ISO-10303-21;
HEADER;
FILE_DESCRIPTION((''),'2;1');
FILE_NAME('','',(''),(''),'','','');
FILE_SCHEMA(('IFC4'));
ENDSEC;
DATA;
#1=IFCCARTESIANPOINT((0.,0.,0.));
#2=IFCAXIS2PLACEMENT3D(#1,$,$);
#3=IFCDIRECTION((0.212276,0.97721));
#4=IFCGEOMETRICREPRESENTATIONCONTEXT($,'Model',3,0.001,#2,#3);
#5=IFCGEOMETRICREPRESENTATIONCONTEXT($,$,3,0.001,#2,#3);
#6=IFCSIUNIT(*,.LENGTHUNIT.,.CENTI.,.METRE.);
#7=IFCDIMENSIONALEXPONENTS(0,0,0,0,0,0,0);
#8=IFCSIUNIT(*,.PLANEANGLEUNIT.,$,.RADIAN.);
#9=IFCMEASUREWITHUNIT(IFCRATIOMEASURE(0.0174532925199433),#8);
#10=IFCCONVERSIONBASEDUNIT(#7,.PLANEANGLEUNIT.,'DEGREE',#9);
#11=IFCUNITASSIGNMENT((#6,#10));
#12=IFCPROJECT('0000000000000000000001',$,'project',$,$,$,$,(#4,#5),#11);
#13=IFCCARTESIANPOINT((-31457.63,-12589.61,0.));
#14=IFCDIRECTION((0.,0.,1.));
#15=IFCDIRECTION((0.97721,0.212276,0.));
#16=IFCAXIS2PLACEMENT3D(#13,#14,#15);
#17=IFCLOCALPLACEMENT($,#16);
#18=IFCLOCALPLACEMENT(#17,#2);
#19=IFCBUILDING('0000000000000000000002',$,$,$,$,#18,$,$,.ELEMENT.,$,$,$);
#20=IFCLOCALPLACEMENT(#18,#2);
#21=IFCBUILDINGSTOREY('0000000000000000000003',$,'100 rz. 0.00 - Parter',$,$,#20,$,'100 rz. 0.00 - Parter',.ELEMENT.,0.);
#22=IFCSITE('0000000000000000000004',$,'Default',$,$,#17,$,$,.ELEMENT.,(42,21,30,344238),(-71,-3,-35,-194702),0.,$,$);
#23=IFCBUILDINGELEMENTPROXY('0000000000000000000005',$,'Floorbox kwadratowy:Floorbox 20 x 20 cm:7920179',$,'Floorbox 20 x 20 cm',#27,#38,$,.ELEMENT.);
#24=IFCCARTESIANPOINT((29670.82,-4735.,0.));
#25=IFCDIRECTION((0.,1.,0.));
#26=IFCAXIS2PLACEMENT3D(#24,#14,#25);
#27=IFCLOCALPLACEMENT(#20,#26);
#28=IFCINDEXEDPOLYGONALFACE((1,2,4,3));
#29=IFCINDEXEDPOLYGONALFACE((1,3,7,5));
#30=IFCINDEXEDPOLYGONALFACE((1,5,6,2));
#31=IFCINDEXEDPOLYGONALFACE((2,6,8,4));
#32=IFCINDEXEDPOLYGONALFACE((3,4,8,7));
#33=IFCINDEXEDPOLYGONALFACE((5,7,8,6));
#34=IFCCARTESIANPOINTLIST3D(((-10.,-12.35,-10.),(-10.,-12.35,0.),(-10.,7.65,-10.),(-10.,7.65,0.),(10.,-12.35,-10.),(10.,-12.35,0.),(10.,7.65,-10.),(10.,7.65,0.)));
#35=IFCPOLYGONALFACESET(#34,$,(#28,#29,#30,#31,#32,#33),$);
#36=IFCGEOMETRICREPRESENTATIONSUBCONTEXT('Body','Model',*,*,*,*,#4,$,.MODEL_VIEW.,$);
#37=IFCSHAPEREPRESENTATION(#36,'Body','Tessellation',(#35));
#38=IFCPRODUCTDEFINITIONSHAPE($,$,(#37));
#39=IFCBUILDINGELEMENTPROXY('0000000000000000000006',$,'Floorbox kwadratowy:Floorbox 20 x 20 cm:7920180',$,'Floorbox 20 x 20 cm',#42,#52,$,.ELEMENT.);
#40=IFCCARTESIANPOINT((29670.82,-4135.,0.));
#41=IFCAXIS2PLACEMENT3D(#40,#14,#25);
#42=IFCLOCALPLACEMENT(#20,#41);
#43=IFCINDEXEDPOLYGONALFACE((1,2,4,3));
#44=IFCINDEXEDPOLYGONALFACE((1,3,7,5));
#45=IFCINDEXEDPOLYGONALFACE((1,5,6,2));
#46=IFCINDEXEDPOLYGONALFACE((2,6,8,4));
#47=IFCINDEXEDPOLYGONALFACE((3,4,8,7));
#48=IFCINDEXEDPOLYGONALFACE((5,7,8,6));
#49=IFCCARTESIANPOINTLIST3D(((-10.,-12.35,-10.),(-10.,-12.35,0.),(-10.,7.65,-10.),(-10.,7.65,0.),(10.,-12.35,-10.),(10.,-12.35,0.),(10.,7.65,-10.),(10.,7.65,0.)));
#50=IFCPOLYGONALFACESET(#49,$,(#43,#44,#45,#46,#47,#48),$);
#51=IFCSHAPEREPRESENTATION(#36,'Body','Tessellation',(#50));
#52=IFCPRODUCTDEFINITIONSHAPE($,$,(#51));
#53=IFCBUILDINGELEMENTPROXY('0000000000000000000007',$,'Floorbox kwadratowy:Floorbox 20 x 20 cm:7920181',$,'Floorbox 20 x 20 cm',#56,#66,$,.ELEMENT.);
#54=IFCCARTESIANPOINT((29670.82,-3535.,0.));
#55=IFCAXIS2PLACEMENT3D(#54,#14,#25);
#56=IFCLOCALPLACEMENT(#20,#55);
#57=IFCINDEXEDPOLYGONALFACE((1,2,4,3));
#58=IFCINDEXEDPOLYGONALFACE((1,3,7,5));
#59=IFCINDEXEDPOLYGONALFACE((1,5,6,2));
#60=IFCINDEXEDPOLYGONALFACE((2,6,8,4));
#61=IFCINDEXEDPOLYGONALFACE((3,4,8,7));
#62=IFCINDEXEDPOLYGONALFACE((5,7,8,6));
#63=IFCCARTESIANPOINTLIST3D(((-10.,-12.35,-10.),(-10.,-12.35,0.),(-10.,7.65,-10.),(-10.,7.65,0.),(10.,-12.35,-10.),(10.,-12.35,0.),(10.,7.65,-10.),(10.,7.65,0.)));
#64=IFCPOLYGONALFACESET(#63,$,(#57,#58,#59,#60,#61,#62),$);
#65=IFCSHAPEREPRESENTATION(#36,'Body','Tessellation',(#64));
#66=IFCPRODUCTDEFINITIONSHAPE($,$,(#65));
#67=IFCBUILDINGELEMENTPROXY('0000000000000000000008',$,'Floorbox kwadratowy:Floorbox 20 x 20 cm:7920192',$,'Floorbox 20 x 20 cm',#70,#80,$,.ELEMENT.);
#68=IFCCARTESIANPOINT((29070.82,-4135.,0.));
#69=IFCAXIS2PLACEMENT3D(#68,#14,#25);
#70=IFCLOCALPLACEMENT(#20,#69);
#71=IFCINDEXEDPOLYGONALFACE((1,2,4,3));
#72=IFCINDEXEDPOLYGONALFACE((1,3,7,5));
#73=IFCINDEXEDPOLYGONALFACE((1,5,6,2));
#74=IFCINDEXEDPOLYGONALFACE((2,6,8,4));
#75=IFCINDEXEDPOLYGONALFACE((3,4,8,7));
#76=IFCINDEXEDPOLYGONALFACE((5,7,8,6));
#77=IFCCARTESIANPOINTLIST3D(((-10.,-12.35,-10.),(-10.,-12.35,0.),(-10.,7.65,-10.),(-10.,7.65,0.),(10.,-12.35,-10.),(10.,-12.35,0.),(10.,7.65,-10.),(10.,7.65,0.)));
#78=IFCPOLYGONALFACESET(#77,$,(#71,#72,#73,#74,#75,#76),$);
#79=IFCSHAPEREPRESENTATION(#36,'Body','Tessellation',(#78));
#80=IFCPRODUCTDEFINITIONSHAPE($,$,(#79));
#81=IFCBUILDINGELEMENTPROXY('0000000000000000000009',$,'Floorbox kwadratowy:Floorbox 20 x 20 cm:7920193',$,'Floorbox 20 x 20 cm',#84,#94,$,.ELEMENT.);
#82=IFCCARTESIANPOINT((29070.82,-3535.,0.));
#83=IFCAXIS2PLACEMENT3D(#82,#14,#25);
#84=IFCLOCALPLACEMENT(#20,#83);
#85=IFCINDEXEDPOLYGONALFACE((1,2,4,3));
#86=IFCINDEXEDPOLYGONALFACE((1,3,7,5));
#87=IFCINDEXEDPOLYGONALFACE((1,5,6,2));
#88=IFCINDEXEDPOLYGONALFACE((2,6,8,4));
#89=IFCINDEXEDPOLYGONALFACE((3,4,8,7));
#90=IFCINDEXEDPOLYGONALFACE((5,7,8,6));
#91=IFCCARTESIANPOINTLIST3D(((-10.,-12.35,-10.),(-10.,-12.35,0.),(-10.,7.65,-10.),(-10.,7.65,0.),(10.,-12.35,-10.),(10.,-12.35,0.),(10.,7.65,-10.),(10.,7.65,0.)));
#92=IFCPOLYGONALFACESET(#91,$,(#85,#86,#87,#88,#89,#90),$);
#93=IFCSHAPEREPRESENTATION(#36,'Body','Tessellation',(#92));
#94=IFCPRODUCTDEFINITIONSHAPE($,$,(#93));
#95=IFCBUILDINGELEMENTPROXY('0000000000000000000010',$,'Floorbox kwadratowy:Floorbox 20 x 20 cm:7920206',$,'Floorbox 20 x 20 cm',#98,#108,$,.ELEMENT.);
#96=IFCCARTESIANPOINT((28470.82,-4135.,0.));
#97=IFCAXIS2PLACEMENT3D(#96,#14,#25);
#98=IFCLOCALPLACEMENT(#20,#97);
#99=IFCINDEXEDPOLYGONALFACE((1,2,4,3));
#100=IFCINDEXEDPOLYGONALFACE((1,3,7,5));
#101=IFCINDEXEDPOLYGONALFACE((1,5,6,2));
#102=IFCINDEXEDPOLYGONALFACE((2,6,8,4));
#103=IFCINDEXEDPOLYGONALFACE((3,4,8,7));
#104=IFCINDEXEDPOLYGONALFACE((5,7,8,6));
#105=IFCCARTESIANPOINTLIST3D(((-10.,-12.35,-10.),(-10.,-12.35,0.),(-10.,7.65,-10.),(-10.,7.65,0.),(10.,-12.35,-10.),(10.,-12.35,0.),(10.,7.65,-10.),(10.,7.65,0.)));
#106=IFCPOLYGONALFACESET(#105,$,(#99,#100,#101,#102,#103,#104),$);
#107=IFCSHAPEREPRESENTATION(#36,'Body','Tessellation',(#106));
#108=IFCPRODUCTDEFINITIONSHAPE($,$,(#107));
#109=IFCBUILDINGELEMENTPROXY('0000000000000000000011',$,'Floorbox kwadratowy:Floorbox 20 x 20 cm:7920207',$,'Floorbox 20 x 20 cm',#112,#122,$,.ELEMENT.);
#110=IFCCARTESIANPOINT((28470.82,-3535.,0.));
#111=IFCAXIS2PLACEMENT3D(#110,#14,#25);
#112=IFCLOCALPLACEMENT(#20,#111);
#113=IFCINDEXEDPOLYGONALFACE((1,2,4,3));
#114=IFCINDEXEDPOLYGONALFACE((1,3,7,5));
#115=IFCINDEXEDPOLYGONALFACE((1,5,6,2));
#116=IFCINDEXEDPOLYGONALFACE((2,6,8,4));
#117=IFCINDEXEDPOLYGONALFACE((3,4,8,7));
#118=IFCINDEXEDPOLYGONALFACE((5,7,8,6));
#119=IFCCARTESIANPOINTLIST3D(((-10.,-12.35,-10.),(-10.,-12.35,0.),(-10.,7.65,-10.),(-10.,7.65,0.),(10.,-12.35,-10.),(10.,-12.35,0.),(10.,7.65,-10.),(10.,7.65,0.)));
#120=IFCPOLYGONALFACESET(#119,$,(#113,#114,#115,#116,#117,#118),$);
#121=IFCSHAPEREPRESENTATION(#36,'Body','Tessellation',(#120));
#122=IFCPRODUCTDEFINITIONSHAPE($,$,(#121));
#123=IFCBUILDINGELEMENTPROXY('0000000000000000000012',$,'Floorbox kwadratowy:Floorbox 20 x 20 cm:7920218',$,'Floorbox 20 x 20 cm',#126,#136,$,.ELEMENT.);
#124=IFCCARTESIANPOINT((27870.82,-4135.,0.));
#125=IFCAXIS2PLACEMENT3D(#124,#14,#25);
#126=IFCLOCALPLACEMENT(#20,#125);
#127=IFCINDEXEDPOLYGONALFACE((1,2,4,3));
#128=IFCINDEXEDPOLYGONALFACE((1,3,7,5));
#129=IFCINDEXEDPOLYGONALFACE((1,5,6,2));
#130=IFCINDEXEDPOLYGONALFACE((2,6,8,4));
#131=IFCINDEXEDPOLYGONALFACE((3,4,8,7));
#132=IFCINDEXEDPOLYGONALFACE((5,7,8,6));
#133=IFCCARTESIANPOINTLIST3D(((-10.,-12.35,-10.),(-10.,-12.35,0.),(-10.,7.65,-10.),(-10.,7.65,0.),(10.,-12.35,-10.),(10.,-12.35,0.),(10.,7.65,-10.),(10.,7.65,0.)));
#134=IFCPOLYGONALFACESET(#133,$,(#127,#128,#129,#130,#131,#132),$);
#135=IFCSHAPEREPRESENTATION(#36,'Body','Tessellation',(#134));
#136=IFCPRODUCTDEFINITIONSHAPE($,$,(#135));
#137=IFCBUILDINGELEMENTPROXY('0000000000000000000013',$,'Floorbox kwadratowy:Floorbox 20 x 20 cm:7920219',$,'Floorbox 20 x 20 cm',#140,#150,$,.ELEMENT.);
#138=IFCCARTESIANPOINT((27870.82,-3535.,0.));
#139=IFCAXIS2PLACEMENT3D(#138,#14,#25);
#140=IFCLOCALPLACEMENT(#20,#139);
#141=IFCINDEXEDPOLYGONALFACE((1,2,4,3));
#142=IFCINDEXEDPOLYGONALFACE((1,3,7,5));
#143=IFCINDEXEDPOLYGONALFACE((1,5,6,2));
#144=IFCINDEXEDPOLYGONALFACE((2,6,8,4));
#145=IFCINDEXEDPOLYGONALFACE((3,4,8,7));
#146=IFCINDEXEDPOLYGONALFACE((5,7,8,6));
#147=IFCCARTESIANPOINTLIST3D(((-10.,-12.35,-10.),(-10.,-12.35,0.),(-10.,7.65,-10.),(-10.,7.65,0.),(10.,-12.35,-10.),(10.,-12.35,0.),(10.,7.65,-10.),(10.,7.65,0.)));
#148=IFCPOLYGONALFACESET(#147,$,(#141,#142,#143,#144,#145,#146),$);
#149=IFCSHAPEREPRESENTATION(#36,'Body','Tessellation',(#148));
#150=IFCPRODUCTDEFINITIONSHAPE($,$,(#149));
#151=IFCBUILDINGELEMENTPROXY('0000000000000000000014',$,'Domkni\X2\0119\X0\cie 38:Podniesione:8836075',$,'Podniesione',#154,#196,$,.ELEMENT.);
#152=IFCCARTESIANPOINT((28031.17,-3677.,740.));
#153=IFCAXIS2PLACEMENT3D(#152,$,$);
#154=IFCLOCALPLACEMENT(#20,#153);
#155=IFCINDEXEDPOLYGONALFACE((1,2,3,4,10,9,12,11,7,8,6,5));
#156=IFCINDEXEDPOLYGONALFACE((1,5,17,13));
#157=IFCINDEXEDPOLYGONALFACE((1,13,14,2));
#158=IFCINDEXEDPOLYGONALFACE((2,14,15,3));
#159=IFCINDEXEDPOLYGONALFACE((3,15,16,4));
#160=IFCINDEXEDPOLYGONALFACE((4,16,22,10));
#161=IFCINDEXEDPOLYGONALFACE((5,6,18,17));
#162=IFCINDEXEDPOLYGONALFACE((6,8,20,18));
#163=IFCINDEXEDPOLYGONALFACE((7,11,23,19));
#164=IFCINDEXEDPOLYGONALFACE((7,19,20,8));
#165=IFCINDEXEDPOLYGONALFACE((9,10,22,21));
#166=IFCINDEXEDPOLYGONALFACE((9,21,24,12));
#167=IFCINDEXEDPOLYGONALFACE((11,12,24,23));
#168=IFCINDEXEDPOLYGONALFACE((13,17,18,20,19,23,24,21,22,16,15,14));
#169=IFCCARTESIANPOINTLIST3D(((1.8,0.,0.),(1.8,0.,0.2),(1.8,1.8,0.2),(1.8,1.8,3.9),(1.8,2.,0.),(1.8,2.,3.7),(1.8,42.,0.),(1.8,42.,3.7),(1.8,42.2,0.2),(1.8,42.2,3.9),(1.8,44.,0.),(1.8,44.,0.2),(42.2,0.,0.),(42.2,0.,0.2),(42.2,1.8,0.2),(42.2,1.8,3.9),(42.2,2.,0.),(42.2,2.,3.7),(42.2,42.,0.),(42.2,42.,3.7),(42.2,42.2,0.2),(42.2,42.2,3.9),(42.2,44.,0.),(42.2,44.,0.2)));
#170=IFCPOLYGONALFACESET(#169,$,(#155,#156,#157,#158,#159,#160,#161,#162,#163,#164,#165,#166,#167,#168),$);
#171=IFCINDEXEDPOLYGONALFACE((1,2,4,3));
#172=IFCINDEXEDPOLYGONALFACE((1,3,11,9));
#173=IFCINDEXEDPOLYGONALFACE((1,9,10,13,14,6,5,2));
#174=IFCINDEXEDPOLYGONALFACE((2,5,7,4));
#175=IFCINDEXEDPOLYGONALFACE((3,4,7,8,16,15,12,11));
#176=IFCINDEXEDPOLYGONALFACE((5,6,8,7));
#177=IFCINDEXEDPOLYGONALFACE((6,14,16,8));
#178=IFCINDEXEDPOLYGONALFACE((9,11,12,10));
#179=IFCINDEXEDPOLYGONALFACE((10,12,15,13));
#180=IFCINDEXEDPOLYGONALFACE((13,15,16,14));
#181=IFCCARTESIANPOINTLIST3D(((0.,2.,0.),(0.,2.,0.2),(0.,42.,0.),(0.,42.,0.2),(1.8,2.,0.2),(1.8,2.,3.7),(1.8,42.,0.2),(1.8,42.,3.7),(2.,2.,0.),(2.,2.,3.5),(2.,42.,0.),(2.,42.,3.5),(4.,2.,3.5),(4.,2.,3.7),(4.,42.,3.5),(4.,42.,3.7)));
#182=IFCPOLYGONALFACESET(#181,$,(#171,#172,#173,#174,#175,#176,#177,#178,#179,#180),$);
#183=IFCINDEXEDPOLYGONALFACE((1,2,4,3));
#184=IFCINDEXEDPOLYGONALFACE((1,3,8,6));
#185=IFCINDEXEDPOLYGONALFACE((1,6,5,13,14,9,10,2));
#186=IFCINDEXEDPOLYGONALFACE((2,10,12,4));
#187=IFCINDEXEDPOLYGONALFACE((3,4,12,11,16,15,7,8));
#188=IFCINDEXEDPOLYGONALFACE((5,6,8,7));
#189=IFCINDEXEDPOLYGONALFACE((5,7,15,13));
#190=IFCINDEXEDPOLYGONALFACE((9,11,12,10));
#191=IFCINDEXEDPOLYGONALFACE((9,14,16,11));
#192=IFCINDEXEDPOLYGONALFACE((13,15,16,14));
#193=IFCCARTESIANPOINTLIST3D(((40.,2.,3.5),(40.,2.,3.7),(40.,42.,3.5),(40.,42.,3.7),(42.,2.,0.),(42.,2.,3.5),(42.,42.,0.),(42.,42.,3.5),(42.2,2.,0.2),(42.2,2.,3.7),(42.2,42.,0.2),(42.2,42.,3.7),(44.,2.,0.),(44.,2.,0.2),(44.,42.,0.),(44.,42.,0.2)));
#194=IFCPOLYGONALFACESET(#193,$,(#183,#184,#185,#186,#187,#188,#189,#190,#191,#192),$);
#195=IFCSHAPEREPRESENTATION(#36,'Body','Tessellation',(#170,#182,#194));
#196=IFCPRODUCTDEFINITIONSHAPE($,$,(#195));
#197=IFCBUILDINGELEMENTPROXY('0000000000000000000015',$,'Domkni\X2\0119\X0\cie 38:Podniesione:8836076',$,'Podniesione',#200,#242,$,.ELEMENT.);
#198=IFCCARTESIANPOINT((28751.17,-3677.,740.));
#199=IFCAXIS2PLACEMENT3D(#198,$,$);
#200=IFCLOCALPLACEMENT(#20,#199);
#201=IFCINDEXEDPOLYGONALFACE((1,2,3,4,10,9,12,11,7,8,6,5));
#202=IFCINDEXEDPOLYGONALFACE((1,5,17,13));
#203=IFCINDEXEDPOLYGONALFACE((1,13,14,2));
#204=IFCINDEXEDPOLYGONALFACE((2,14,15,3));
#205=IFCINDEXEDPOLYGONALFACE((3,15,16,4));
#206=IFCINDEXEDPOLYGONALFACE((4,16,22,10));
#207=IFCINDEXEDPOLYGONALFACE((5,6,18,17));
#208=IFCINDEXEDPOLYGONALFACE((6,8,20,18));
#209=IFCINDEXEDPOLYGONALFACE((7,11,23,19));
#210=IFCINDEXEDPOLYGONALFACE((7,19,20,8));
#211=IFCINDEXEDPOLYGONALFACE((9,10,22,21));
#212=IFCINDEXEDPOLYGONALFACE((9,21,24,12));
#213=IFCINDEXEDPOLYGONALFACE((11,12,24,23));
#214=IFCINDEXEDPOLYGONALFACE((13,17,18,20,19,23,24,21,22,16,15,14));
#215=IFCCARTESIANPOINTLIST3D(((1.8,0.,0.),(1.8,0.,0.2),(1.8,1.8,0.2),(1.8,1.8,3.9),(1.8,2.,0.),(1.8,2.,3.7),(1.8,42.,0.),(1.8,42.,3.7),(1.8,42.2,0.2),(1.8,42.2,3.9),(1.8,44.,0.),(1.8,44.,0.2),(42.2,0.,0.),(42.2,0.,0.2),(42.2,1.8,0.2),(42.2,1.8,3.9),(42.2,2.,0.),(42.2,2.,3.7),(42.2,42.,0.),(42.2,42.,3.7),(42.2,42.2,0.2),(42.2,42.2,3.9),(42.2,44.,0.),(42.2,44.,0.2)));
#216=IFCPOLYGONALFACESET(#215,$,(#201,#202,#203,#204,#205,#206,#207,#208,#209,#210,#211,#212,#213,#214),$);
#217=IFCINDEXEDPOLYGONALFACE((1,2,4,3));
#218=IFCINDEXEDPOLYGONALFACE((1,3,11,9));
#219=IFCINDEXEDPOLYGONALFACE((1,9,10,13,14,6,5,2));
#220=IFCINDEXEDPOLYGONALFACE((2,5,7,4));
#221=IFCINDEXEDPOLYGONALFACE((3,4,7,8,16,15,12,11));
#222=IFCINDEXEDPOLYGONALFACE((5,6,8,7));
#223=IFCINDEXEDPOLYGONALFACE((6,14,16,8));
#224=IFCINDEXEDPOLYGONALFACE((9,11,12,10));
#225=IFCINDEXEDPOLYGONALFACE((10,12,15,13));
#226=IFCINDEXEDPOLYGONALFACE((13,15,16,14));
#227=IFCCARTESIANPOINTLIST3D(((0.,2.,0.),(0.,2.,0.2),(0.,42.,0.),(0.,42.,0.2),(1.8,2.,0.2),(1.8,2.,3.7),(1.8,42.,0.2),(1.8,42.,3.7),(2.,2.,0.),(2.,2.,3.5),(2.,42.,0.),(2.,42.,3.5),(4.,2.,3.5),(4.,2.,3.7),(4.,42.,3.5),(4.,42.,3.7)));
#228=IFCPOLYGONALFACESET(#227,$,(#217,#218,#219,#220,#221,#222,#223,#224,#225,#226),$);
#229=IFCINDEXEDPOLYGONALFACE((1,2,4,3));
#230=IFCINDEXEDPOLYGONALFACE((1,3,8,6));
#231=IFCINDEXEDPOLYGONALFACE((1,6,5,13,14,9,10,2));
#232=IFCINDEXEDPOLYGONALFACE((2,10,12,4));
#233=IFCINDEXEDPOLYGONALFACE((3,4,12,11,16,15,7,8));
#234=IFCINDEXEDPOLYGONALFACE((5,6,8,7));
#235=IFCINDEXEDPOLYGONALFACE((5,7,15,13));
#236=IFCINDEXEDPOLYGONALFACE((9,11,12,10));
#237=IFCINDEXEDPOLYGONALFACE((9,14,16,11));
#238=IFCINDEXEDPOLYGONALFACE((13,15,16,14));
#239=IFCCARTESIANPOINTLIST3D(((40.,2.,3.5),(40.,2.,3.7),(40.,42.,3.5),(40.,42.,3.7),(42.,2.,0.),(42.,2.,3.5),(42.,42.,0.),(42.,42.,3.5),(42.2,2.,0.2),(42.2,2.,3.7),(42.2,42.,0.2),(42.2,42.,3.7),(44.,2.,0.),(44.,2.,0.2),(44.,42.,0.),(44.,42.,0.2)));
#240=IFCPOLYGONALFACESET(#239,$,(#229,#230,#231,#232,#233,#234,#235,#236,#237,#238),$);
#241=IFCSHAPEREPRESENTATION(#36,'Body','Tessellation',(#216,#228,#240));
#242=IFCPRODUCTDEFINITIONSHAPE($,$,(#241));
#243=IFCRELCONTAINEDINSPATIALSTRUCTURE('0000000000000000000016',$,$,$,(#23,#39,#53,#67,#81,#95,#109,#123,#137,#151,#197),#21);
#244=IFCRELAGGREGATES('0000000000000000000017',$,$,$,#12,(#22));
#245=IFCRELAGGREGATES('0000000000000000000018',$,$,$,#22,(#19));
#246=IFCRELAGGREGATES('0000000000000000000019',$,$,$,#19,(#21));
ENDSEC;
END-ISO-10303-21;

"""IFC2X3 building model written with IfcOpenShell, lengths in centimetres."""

from ifc_helpers import new_model, entity, si_unit, converted_unit, direction, frame, origin, origin_2d_with_axis, place, context, subcontext, project, spatial, polyline, rectangle, outline, extrude, source, transform, mapped, element, save


model = new_model("IFC2X3")

# Units and contexts
model_context = context("Model", 3, precision=0.001, world=origin(), true_north=direction((0.212276, 0.97721)))
context_of_model = context(None, 3, precision=0.001, world=origin(), true_north=direction((0.212276, 0.97721)))
body_context = subcontext(model_context, "Body", "Model", "MODEL_VIEW")
ifc_project = project(units=[si_unit("LENGTHUNIT", "METRE", prefix="CENTI"), converted_unit("PLANEANGLEUNIT", "DEGREE", entity("IfcRatioMeasure", 0.0174532925199433), si_unit("PLANEANGLEUNIT", "RADIAN"), dimensions=[0, 0, 0, 0, 0, 0, 0])], contexts=[model_context, context_of_model])

# Site, building, storey
site_placement = place(None, frame((-31457.63, -12589.61, 0.0), z_axis=(0.0, 0.0, 1.0), x_axis=(0.97721, 0.212276, 0.0)))
site = spatial("IfcSite", under=ifc_project, at=site_placement, Name="Default", CompositionType="ELEMENT", RefLatitude=(42, 21, 30, 344238), RefLongitude=(-71, -3, -35, -194702), RefElevation=0.0)
building_placement = place(site_placement, origin())
building = spatial("IfcBuilding", under=site, at=building_placement, CompositionType="ELEMENT")
storey_placement = place(building_placement, origin())
storey = spatial("IfcBuildingStorey", under=building, at=storey_placement, Name="100 rz. 0.00 - Parter", LongName="100 rz. 0.00 - Parter", CompositionType="ELEMENT", Elevation=0.0)

# Building element proxies
shared_shape_1 = source(origin(), body_context, "Body", "SweptSolid", [
    extrude(rectangle(XDim=20.0, YDim=20.0, at=origin_2d_with_axis()), frame((0.0, -2.35, -10.0), z_axis=(0.0, 0.0, 1.0), x_axis=(-1.0, 0.0, 0.0)), (0.0, 0.0, 1.0), 10.0),
])
for number, where, z_axis, x_axis, name in (
    (1, (29670.82, -4735.0, 0.0), (0.0, 0.0, 1.0), (0.0, 1.0, 0.0), "Floorbox kwadratowy:Floorbox 20 x 20 cm:7920179"),
    (2, (29670.82, -4135.0, 0.0), (0.0, 0.0, 1.0), (0.0, 1.0, 0.0), "Floorbox kwadratowy:Floorbox 20 x 20 cm:7920180"),
    (3, (29670.82, -3535.0, 0.0), (0.0, 0.0, 1.0), (0.0, 1.0, 0.0), "Floorbox kwadratowy:Floorbox 20 x 20 cm:7920181"),
    (4, (29070.82, -4135.0, 0.0), (0.0, 0.0, 1.0), (0.0, 1.0, 0.0), "Floorbox kwadratowy:Floorbox 20 x 20 cm:7920192"),
    (5, (29070.82, -3535.0, 0.0), (0.0, 0.0, 1.0), (0.0, 1.0, 0.0), "Floorbox kwadratowy:Floorbox 20 x 20 cm:7920193"),
    (6, (28470.82, -4135.0, 0.0), (0.0, 0.0, 1.0), (0.0, 1.0, 0.0), "Floorbox kwadratowy:Floorbox 20 x 20 cm:7920206"),
    (7, (28470.82, -3535.0, 0.0), (0.0, 0.0, 1.0), (0.0, 1.0, 0.0), "Floorbox kwadratowy:Floorbox 20 x 20 cm:7920207"),
    (8, (27870.82, -4135.0, 0.0), (0.0, 0.0, 1.0), (0.0, 1.0, 0.0), "Floorbox kwadratowy:Floorbox 20 x 20 cm:7920218"),
    (9, (27870.82, -3535.0, 0.0), (0.0, 0.0, 1.0), (0.0, 1.0, 0.0), "Floorbox kwadratowy:Floorbox 20 x 20 cm:7920219"),
):
    element("IfcBuildingElementProxy", number, at=place(storey_placement, frame(where, z_axis=z_axis, x_axis=x_axis)), inside=storey, Name=name, ObjectType="Floorbox 20 x 20 cm", CompositionType="ELEMENT", context=body_context, shape_type="MappedRepresentation", body=[
        mapped(shared_shape_1, transform((0.0, 0.0, 0.0), scale=1.0)),
    ])
shared_shape_2 = source(origin(), body_context, "Body", "SweptSolid", [
    extrude(outline(polyline([(-2.37, 20.0), (1.33, 20.0), (1.33, 22.0), (1.13, 22.0), (1.13, 20.2), (-2.57, 20.2), (-2.57, -20.2), (1.13, -20.2), (1.13, -22.0), (1.33, -22.0), (1.33, -20.0), (-2.37, -20.0), (-2.37, 20.0)])), frame((1.8, 22.0, 1.33), z_axis=(1.0, 0.0, 0.0), x_axis=(0.0, 0.0, -1.0)), (0.0, 0.0, 1.0), 40.4),
    extrude(outline(polyline([(-1.65, -0.05), (1.85, -0.05), (1.85, 1.95), (1.65, 1.95), (1.65, 0.15), (-1.85, 0.15), (-1.85, -2.05), (-1.65, -2.05), (-1.65, -0.05)])), frame((1.95, 2.0, 1.85), z_axis=(0.0, 1.0, 0.0), x_axis=(0.0, 0.0, -1.0)), (0.0, 0.0, 1.0), 40.0),
    extrude(outline(polyline([(0.05, 1.65), (2.05, 1.65), (2.05, 1.85), (-0.15, 1.85), (-0.15, -1.65), (-1.95, -1.65), (-1.95, -1.85), (0.05, -1.85), (0.05, 1.65)])), frame((42.05, 2.0, 1.85), z_axis=(0.0, 1.0, 0.0), x_axis=(-1.0, 0.0, 0.0)), (0.0, 0.0, 1.0), 40.0),
])
for number, where, name in (
    (10, (28031.17, -3677.0, 740.0), "Domknięcie 38:Podniesione:8836075"),
    (11, (28751.17, -3677.0, 740.0), "Domknięcie 38:Podniesione:8836076"),
):
    element("IfcBuildingElementProxy", number, at=place(storey_placement, frame(where)), inside=storey, Name=name, ObjectType="Podniesione", CompositionType="ELEMENT", context=body_context, shape_type="MappedRepresentation", body=[
        mapped(shared_shape_2, transform((0.0, 0.0, 0.0), scale=1.0)),
    ])

save(model, "model.ifc")
